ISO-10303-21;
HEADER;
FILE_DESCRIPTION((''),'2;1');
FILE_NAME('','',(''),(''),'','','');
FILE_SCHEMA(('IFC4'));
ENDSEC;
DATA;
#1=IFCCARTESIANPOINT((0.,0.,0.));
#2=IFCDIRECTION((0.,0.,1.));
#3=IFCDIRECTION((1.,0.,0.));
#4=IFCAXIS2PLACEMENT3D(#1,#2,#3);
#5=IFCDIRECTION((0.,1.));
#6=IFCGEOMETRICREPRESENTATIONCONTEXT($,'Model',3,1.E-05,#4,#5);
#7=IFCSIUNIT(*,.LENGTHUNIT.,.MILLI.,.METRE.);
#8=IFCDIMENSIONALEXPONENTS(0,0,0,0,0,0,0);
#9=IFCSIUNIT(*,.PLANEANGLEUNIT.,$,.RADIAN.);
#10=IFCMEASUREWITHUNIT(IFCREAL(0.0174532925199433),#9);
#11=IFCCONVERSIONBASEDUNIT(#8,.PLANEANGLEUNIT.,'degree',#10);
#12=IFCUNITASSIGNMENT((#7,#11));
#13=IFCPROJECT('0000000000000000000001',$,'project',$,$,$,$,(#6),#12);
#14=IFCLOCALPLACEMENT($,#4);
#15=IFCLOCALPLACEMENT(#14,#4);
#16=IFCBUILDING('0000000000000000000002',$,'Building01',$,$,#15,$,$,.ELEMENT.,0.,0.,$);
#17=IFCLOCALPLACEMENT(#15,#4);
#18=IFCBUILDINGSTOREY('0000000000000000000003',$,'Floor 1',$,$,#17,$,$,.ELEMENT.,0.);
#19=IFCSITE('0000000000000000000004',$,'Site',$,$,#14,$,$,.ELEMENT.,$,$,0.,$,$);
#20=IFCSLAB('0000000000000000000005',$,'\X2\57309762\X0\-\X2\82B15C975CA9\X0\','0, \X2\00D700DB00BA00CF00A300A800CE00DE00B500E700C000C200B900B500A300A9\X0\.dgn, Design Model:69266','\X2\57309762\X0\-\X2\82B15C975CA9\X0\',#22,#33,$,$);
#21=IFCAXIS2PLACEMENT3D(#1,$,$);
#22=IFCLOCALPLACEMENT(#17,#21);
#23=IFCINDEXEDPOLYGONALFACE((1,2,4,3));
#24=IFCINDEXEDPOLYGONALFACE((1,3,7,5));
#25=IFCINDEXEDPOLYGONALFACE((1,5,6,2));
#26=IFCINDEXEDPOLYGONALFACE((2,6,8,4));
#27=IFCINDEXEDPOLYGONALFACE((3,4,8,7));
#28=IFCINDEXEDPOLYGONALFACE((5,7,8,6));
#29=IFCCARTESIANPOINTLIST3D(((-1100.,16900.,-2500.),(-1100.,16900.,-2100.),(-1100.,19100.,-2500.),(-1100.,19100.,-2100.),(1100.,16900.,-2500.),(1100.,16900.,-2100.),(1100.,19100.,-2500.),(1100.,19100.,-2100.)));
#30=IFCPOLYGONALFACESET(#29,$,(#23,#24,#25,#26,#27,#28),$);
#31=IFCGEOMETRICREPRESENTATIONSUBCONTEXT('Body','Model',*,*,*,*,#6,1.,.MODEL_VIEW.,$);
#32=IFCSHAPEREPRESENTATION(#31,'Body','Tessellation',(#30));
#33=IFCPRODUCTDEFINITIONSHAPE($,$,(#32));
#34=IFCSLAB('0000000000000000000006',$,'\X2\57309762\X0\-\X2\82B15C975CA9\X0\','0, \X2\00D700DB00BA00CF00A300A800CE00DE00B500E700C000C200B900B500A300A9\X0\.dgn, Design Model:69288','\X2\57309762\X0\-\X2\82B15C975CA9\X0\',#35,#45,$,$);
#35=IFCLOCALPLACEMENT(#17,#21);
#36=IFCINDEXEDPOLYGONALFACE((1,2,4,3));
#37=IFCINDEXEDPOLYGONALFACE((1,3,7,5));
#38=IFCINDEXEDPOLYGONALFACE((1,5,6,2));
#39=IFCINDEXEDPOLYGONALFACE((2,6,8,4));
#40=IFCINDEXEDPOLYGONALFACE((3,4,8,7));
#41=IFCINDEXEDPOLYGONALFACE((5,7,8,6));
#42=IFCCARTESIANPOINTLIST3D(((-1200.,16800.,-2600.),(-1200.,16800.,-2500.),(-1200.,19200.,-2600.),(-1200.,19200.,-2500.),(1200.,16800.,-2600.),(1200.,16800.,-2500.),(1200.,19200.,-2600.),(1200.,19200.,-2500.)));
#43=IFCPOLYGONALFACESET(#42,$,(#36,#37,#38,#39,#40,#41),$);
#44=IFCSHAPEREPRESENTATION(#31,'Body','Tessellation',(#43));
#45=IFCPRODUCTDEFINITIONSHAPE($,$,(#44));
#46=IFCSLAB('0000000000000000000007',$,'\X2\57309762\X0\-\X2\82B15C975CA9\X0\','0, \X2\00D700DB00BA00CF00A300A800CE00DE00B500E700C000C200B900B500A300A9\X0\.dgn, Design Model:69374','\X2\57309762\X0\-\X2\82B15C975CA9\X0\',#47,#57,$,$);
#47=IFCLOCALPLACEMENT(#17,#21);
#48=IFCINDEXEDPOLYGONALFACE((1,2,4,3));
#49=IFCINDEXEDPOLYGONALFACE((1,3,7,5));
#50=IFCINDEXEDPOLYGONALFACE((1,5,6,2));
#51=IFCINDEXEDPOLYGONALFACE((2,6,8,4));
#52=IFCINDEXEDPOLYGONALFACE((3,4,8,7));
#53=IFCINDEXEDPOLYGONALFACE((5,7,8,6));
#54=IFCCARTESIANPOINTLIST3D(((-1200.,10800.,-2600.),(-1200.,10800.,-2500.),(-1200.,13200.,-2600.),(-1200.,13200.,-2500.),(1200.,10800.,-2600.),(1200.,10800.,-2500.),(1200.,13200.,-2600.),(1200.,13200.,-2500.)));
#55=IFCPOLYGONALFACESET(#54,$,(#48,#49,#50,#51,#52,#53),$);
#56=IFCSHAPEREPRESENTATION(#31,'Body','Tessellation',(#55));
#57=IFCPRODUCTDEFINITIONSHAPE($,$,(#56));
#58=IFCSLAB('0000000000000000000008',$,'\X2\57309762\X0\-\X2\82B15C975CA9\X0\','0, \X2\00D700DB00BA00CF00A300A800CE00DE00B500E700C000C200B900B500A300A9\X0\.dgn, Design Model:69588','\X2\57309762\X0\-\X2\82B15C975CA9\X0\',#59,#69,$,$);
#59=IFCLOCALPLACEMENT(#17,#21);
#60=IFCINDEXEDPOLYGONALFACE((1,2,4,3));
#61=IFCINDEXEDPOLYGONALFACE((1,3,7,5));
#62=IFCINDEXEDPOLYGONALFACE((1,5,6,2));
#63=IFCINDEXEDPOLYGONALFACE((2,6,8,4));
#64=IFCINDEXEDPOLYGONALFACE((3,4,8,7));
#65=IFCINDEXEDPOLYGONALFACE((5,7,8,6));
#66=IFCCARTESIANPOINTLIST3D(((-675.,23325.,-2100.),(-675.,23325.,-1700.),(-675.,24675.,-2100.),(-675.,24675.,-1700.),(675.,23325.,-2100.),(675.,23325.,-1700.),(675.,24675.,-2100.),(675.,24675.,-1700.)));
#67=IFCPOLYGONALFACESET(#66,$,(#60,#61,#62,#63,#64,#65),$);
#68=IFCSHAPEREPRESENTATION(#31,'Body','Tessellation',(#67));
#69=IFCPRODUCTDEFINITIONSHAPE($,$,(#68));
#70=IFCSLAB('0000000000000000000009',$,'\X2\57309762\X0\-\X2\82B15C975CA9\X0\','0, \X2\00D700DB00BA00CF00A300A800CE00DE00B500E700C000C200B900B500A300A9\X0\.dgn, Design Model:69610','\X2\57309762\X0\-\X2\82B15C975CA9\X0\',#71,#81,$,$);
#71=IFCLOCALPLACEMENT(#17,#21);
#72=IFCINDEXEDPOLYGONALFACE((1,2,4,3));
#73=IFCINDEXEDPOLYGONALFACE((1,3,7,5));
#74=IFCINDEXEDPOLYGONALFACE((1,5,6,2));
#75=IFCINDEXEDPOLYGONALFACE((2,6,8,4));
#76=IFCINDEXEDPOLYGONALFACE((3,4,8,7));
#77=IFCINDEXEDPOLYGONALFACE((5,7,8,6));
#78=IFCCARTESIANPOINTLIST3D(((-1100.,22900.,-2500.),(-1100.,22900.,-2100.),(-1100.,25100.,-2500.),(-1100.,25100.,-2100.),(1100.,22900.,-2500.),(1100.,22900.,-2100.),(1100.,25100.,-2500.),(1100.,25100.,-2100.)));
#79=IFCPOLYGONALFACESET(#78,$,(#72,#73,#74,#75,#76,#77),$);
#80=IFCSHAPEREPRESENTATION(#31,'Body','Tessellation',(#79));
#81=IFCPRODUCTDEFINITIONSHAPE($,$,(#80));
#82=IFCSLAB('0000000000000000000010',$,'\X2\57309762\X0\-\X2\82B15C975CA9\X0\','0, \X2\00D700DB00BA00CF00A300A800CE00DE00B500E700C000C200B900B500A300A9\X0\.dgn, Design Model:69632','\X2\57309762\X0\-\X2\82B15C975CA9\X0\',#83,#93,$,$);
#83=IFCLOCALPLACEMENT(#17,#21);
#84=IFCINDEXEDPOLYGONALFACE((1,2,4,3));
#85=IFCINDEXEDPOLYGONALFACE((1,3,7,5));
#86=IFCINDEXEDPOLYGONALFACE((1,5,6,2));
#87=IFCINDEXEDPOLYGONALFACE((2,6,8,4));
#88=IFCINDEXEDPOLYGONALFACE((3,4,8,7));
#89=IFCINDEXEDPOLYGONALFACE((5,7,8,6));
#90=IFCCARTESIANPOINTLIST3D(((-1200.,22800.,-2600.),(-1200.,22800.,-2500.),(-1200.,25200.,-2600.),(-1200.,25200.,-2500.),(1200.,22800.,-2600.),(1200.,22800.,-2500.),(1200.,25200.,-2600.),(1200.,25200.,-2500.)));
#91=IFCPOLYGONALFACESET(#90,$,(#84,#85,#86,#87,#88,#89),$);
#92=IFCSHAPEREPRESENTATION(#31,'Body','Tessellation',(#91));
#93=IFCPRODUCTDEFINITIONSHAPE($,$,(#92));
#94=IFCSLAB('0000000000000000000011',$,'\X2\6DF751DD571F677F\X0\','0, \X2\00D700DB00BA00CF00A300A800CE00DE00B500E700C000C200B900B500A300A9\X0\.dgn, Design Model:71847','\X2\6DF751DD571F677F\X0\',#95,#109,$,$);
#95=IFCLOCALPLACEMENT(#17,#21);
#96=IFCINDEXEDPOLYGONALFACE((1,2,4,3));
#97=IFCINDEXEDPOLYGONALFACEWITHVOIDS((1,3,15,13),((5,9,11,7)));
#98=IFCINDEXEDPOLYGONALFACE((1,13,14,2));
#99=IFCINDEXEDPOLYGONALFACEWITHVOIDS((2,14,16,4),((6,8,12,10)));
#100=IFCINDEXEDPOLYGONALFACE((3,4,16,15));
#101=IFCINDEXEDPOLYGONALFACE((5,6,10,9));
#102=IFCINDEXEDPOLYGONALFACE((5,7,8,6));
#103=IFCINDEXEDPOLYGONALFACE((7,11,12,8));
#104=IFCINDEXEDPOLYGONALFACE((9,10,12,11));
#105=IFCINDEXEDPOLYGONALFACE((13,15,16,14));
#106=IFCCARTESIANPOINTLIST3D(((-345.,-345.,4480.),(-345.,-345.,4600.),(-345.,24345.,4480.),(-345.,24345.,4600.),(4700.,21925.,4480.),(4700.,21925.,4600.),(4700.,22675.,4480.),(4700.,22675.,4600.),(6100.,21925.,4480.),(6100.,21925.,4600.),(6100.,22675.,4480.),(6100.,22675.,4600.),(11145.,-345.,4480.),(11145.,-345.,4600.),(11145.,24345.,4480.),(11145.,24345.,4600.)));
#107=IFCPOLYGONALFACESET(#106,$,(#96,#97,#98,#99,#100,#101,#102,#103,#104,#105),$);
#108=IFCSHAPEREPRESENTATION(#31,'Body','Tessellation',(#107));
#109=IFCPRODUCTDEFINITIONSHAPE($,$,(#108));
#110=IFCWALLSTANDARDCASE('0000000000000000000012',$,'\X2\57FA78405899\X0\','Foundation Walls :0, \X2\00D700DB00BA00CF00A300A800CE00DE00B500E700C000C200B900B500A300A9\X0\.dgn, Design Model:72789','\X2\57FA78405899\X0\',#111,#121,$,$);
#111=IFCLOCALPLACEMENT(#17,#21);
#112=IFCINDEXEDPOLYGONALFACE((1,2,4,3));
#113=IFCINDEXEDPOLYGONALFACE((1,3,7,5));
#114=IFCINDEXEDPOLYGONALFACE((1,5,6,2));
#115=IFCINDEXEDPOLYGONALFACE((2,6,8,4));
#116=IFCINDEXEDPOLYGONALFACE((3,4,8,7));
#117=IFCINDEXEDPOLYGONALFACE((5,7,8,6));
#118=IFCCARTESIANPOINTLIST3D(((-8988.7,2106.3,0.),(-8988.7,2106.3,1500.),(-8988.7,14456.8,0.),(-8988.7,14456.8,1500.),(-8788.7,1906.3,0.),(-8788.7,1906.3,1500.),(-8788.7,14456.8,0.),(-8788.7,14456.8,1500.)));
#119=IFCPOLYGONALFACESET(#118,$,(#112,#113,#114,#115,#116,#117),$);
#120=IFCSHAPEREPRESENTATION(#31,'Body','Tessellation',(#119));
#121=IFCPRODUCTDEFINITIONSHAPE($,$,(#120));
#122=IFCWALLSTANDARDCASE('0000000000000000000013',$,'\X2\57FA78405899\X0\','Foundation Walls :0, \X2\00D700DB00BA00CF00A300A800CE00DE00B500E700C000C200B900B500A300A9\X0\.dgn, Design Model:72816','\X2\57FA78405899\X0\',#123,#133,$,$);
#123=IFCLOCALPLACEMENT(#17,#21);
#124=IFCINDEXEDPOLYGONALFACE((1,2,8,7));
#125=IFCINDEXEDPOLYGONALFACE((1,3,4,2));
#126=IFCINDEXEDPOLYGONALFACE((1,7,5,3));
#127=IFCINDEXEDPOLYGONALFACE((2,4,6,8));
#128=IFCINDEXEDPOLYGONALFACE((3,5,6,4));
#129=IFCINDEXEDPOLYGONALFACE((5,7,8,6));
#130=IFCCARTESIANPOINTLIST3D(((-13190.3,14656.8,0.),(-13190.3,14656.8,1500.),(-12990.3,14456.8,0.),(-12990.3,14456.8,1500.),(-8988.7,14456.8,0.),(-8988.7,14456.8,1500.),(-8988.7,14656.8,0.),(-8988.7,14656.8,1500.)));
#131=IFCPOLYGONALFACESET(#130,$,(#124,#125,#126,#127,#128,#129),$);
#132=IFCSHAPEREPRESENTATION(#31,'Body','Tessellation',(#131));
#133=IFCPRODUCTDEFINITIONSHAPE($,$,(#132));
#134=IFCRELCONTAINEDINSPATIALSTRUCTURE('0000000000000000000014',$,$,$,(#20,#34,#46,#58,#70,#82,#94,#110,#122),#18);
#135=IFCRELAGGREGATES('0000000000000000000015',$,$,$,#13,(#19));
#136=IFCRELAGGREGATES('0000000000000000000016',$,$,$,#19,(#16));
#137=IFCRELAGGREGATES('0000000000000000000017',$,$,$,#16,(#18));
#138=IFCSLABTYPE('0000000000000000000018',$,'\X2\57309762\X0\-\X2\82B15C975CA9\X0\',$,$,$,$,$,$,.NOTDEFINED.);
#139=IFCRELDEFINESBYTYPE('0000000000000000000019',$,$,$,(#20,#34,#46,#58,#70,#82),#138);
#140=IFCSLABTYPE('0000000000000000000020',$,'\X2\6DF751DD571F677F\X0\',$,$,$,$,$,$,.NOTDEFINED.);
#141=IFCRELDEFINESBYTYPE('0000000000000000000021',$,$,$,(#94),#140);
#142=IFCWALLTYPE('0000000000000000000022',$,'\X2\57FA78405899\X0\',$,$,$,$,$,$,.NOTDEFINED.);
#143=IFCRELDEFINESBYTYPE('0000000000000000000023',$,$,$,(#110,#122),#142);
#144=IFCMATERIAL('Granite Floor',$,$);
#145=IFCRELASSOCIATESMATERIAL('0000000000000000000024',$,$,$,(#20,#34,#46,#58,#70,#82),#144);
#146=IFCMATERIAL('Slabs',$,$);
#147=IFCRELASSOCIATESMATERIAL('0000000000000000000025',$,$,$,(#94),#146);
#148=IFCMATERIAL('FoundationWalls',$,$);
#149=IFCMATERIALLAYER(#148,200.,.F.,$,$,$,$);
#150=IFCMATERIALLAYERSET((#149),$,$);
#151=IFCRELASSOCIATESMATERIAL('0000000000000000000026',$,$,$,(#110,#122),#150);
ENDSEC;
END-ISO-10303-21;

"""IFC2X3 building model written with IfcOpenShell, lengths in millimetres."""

from ifc_helpers import new_model, entity, si_unit, converted_unit, direction, frame, frame_2d, origin_with_axes, place, context, subcontext, project, spatial, polyline, rectangle, outline, extrude, material, layer, layer_set, layer_usage, type_object, element, save


model = new_model("IFC2X3")

# Units and contexts
model_context = context("Model", 3, precision=1e-05, world=origin_with_axes(), true_north=direction((0.0, 1.0)))
body_context = subcontext(model_context, "Body", "Model", "MODEL_VIEW", scale=1.0)
ifc_project = project(units=[si_unit("LENGTHUNIT", "METRE", prefix="MILLI"), converted_unit("PLANEANGLEUNIT", "degree", entity("IfcReal", 0.0174532925199433), si_unit("PLANEANGLEUNIT", "RADIAN"), dimensions=[0, 0, 0, 0, 0, 0, 0])], contexts=[model_context])

# Site, building, storey
site_placement = place(None, origin_with_axes())
site = spatial("IfcSite", under=ifc_project, at=site_placement, Name="Site", CompositionType="ELEMENT", RefElevation=0.0)
building_placement = place(site_placement, origin_with_axes())
building = spatial("IfcBuilding", under=site, at=building_placement, Name="Building01", CompositionType="ELEMENT", ElevationOfRefHeight=0.0, ElevationOfTerrain=0.0)
storey_placement = place(building_placement, origin_with_axes())
storey = spatial("IfcBuildingStorey", under=building, at=storey_placement, Name="Floor 1", CompositionType="ELEMENT", Elevation=0.0)

# Slabs
ifc_material_1 = material(Name="Granite Floor")
slab_type_1 = type_object("IfcSlabType", Name="地面-花岗岩", PredefinedType="NOTDEFINED")
slab_1_placement = place(storey_placement, frame((-1100.0, 16900.0, -2500.0), z_axis=(0.0, 0.0, 1.0), x_axis=(1.0, 0.0, 0.0)))
element("IfcSlab", 1, at=slab_1_placement, inside=storey, type_object=slab_type_1, material=ifc_material_1, Name="地面-花岗岩", Description="0, ×ÛºÏ£¨ÎÞµçÀÂ¹µ£©.dgn, Design Model:69266", ObjectType="地面-花岗岩", context=body_context, shape_type="SweptSolid", body=[
    extrude(rectangle(XDim=2200.0, YDim=2200.0, at=frame_2d((1100.0, 1100.0), x_axis=(1.0, 0.0))), origin_with_axes(), (0.0, 0.0, 1.0), 400.0),
])
for number, where, z_axis, x_axis, name, description in (
    (2, (1200.0, 19200.0, -2500.0), (0.0, 0.0, -1.0), (0.0, -1.0, 0.0), "地面-花岗岩", "0, ×ÛºÏ£¨ÎÞµçÀÂ¹µ£©.dgn, Design Model:69288"),
    (3, (1200.0, 13200.0, -2500.0), (0.0, 0.0, -1.0), (0.0, -1.0, 0.0), "地面-花岗岩", "0, ×ÛºÏ£¨ÎÞµçÀÂ¹µ£©.dgn, Design Model:69374"),
):
    element("IfcSlab", number, at=place(storey_placement, frame(where, z_axis=z_axis, x_axis=x_axis)), inside=storey, type_object=slab_type_1, material=ifc_material_1, Name=name, Description=description, ObjectType="地面-花岗岩", context=body_context, shape_type="SweptSolid", body=[
        extrude(rectangle(XDim=2400.0, YDim=2400.0, at=frame_2d((1200.0, 1200.0), x_axis=(1.0, 0.0))), origin_with_axes(), (0.0, 0.0, 1.0), 100.0),
    ])
slab_2_placement = place(storey_placement, frame((-675.0, 23325.0, -2100.0), z_axis=(0.0, 0.0, 1.0), x_axis=(1.0, 0.0, 0.0)))
element("IfcSlab", 4, at=slab_2_placement, inside=storey, type_object=slab_type_1, material=ifc_material_1, Name="地面-花岗岩", Description="0, ×ÛºÏ£¨ÎÞµçÀÂ¹µ£©.dgn, Design Model:69588", ObjectType="地面-花岗岩", context=body_context, shape_type="SweptSolid", body=[
    extrude(rectangle(XDim=1350.0, YDim=1350.0, at=frame_2d((675.0, 675.0), x_axis=(1.0, 0.0))), origin_with_axes(), (0.0, 0.0, 1.0), 400.0),
])
slab_3_placement = place(storey_placement, frame((-1100.0, 22900.0, -2500.0), z_axis=(0.0, 0.0, 1.0), x_axis=(1.0, 0.0, 0.0)))
element("IfcSlab", 5, at=slab_3_placement, inside=storey, type_object=slab_type_1, material=ifc_material_1, Name="地面-花岗岩", Description="0, ×ÛºÏ£¨ÎÞµçÀÂ¹µ£©.dgn, Design Model:69610", ObjectType="地面-花岗岩", context=body_context, shape_type="SweptSolid", body=[
    extrude(rectangle(XDim=2200.0, YDim=2200.0, at=frame_2d((1100.0, 1100.0), x_axis=(1.0, 0.0))), origin_with_axes(), (0.0, 0.0, 1.0), 400.0),
])
slab_4_placement = place(storey_placement, frame((1200.0, 25200.0, -2500.0), z_axis=(0.0, 0.0, -1.0), x_axis=(0.0, -1.0, 0.0)))
element("IfcSlab", 6, at=slab_4_placement, inside=storey, type_object=slab_type_1, material=ifc_material_1, Name="地面-花岗岩", Description="0, ×ÛºÏ£¨ÎÞµçÀÂ¹µ£©.dgn, Design Model:69632", ObjectType="地面-花岗岩", context=body_context, shape_type="SweptSolid", body=[
    extrude(rectangle(XDim=2400.0, YDim=2400.0, at=frame_2d((1200.0, 1200.0), x_axis=(1.0, 0.0))), origin_with_axes(), (0.0, 0.0, 1.0), 100.0),
])

# Slab, opening
ifc_material_2 = material(Name="Slabs")
slab_type_2 = type_object("IfcSlabType", Name="混凝土板", PredefinedType="NOTDEFINED")
slab_5_placement = place(storey_placement, frame((-345.0, 24345.0, 4480.0), z_axis=(0.0, 0.0, 1.0), x_axis=(0.0, -1.0, 0.0)))
slab_5 = element("IfcSlab", 7, at=slab_5_placement, inside=storey, type_object=slab_type_2, material=ifc_material_2, Name="混凝土板", Description="0, ×ÛºÏ£¨ÎÞµçÀÂ¹µ£©.dgn, Design Model:71847", ObjectType="混凝土板", context=body_context, shape_type="SweptSolid", body=[
    extrude(rectangle(XDim=24690.0, YDim=11490.0, at=frame_2d((12345.0, 5745.0), x_axis=(1.0, 0.0))), origin_with_axes(), (0.0, 0.0, 1.0), 120.0),
])
opening_placement = place(slab_5_placement, frame((1670.0, 5045.0, 0.0), z_axis=(0.0, 0.0, 1.0), x_axis=(1.0, 0.0, 0.0)))
element("IfcOpeningElement", 8, at=opening_placement, cuts=slab_5, ObjectType="Opening", context=body_context, shape_type="SweptSolid", body=[
    extrude(rectangle(XDim=1400.0, YDim=750.0, at=frame_2d((375.0, 700.0), x_axis=(0.0, -1.0))), frame((0.0, 0.0, -180.0), z_axis=(0.0, 0.0, 1.0), x_axis=(1.0, 0.0, 0.0)), (0.0, 0.0, 1.0), 360.0),
])

# Walls
ifc_material_3 = material(Name="FoundationWalls")
ifc_layer = layer(ifc_material_3, 200.0, ventilated=False)
ifc_layer_set = layer_set([ifc_layer])
ifc_layer_usage = layer_usage(ifc_layer_set, "AXIS2", "POSITIVE", 0.0)
wall_type = type_object("IfcWallType", Name="基础墙", PredefinedType="NOTDEFINED")
wall_1_placement = place(storey_placement, frame((-8988.7, 14456.8, 0.0), z_axis=(0.0, 0.0, 1.0), x_axis=(0.0, -1.0, 0.0)))
element("IfcWallStandardCase", 9, at=wall_1_placement, inside=storey, type_object=wall_type, material=ifc_layer_usage, Name="基础墙", Description="Foundation Walls :0, ×ÛºÏ£¨ÎÞµçÀÂ¹µ£©.dgn, Design Model:72789", ObjectType="基础墙", context=body_context, shape_type="SweptSolid", body=[
    extrude(outline(polyline([(12550.5, 200.0), (0.0, 200.0), (0.0, 0.0), (12350.5, 0.0), (12550.5, 200.0)])), origin_with_axes(), (0.0, 0.0, 1.0), 1500.0),
])
wall_2_placement = place(storey_placement, frame((-12990.3, 14456.8, 0.0), z_axis=(0.0, 0.0, 1.0), x_axis=(1.0, 0.0, 0.0)))
element("IfcWallStandardCase", 10, at=wall_2_placement, inside=storey, type_object=wall_type, material=ifc_layer_usage, Name="基础墙", Description="Foundation Walls :0, ×ÛºÏ£¨ÎÞµçÀÂ¹µ£©.dgn, Design Model:72816", ObjectType="基础墙", context=body_context, shape_type="SweptSolid", body=[
    extrude(outline(polyline([(-200.0, 200.0), (0.0, 0.0), (4001.6, 0.0), (4001.6, 200.0), (-200.0, 200.0)])), origin_with_axes(), (0.0, 0.0, 1.0), 1500.0),
])

save(model, "model.ifc")
